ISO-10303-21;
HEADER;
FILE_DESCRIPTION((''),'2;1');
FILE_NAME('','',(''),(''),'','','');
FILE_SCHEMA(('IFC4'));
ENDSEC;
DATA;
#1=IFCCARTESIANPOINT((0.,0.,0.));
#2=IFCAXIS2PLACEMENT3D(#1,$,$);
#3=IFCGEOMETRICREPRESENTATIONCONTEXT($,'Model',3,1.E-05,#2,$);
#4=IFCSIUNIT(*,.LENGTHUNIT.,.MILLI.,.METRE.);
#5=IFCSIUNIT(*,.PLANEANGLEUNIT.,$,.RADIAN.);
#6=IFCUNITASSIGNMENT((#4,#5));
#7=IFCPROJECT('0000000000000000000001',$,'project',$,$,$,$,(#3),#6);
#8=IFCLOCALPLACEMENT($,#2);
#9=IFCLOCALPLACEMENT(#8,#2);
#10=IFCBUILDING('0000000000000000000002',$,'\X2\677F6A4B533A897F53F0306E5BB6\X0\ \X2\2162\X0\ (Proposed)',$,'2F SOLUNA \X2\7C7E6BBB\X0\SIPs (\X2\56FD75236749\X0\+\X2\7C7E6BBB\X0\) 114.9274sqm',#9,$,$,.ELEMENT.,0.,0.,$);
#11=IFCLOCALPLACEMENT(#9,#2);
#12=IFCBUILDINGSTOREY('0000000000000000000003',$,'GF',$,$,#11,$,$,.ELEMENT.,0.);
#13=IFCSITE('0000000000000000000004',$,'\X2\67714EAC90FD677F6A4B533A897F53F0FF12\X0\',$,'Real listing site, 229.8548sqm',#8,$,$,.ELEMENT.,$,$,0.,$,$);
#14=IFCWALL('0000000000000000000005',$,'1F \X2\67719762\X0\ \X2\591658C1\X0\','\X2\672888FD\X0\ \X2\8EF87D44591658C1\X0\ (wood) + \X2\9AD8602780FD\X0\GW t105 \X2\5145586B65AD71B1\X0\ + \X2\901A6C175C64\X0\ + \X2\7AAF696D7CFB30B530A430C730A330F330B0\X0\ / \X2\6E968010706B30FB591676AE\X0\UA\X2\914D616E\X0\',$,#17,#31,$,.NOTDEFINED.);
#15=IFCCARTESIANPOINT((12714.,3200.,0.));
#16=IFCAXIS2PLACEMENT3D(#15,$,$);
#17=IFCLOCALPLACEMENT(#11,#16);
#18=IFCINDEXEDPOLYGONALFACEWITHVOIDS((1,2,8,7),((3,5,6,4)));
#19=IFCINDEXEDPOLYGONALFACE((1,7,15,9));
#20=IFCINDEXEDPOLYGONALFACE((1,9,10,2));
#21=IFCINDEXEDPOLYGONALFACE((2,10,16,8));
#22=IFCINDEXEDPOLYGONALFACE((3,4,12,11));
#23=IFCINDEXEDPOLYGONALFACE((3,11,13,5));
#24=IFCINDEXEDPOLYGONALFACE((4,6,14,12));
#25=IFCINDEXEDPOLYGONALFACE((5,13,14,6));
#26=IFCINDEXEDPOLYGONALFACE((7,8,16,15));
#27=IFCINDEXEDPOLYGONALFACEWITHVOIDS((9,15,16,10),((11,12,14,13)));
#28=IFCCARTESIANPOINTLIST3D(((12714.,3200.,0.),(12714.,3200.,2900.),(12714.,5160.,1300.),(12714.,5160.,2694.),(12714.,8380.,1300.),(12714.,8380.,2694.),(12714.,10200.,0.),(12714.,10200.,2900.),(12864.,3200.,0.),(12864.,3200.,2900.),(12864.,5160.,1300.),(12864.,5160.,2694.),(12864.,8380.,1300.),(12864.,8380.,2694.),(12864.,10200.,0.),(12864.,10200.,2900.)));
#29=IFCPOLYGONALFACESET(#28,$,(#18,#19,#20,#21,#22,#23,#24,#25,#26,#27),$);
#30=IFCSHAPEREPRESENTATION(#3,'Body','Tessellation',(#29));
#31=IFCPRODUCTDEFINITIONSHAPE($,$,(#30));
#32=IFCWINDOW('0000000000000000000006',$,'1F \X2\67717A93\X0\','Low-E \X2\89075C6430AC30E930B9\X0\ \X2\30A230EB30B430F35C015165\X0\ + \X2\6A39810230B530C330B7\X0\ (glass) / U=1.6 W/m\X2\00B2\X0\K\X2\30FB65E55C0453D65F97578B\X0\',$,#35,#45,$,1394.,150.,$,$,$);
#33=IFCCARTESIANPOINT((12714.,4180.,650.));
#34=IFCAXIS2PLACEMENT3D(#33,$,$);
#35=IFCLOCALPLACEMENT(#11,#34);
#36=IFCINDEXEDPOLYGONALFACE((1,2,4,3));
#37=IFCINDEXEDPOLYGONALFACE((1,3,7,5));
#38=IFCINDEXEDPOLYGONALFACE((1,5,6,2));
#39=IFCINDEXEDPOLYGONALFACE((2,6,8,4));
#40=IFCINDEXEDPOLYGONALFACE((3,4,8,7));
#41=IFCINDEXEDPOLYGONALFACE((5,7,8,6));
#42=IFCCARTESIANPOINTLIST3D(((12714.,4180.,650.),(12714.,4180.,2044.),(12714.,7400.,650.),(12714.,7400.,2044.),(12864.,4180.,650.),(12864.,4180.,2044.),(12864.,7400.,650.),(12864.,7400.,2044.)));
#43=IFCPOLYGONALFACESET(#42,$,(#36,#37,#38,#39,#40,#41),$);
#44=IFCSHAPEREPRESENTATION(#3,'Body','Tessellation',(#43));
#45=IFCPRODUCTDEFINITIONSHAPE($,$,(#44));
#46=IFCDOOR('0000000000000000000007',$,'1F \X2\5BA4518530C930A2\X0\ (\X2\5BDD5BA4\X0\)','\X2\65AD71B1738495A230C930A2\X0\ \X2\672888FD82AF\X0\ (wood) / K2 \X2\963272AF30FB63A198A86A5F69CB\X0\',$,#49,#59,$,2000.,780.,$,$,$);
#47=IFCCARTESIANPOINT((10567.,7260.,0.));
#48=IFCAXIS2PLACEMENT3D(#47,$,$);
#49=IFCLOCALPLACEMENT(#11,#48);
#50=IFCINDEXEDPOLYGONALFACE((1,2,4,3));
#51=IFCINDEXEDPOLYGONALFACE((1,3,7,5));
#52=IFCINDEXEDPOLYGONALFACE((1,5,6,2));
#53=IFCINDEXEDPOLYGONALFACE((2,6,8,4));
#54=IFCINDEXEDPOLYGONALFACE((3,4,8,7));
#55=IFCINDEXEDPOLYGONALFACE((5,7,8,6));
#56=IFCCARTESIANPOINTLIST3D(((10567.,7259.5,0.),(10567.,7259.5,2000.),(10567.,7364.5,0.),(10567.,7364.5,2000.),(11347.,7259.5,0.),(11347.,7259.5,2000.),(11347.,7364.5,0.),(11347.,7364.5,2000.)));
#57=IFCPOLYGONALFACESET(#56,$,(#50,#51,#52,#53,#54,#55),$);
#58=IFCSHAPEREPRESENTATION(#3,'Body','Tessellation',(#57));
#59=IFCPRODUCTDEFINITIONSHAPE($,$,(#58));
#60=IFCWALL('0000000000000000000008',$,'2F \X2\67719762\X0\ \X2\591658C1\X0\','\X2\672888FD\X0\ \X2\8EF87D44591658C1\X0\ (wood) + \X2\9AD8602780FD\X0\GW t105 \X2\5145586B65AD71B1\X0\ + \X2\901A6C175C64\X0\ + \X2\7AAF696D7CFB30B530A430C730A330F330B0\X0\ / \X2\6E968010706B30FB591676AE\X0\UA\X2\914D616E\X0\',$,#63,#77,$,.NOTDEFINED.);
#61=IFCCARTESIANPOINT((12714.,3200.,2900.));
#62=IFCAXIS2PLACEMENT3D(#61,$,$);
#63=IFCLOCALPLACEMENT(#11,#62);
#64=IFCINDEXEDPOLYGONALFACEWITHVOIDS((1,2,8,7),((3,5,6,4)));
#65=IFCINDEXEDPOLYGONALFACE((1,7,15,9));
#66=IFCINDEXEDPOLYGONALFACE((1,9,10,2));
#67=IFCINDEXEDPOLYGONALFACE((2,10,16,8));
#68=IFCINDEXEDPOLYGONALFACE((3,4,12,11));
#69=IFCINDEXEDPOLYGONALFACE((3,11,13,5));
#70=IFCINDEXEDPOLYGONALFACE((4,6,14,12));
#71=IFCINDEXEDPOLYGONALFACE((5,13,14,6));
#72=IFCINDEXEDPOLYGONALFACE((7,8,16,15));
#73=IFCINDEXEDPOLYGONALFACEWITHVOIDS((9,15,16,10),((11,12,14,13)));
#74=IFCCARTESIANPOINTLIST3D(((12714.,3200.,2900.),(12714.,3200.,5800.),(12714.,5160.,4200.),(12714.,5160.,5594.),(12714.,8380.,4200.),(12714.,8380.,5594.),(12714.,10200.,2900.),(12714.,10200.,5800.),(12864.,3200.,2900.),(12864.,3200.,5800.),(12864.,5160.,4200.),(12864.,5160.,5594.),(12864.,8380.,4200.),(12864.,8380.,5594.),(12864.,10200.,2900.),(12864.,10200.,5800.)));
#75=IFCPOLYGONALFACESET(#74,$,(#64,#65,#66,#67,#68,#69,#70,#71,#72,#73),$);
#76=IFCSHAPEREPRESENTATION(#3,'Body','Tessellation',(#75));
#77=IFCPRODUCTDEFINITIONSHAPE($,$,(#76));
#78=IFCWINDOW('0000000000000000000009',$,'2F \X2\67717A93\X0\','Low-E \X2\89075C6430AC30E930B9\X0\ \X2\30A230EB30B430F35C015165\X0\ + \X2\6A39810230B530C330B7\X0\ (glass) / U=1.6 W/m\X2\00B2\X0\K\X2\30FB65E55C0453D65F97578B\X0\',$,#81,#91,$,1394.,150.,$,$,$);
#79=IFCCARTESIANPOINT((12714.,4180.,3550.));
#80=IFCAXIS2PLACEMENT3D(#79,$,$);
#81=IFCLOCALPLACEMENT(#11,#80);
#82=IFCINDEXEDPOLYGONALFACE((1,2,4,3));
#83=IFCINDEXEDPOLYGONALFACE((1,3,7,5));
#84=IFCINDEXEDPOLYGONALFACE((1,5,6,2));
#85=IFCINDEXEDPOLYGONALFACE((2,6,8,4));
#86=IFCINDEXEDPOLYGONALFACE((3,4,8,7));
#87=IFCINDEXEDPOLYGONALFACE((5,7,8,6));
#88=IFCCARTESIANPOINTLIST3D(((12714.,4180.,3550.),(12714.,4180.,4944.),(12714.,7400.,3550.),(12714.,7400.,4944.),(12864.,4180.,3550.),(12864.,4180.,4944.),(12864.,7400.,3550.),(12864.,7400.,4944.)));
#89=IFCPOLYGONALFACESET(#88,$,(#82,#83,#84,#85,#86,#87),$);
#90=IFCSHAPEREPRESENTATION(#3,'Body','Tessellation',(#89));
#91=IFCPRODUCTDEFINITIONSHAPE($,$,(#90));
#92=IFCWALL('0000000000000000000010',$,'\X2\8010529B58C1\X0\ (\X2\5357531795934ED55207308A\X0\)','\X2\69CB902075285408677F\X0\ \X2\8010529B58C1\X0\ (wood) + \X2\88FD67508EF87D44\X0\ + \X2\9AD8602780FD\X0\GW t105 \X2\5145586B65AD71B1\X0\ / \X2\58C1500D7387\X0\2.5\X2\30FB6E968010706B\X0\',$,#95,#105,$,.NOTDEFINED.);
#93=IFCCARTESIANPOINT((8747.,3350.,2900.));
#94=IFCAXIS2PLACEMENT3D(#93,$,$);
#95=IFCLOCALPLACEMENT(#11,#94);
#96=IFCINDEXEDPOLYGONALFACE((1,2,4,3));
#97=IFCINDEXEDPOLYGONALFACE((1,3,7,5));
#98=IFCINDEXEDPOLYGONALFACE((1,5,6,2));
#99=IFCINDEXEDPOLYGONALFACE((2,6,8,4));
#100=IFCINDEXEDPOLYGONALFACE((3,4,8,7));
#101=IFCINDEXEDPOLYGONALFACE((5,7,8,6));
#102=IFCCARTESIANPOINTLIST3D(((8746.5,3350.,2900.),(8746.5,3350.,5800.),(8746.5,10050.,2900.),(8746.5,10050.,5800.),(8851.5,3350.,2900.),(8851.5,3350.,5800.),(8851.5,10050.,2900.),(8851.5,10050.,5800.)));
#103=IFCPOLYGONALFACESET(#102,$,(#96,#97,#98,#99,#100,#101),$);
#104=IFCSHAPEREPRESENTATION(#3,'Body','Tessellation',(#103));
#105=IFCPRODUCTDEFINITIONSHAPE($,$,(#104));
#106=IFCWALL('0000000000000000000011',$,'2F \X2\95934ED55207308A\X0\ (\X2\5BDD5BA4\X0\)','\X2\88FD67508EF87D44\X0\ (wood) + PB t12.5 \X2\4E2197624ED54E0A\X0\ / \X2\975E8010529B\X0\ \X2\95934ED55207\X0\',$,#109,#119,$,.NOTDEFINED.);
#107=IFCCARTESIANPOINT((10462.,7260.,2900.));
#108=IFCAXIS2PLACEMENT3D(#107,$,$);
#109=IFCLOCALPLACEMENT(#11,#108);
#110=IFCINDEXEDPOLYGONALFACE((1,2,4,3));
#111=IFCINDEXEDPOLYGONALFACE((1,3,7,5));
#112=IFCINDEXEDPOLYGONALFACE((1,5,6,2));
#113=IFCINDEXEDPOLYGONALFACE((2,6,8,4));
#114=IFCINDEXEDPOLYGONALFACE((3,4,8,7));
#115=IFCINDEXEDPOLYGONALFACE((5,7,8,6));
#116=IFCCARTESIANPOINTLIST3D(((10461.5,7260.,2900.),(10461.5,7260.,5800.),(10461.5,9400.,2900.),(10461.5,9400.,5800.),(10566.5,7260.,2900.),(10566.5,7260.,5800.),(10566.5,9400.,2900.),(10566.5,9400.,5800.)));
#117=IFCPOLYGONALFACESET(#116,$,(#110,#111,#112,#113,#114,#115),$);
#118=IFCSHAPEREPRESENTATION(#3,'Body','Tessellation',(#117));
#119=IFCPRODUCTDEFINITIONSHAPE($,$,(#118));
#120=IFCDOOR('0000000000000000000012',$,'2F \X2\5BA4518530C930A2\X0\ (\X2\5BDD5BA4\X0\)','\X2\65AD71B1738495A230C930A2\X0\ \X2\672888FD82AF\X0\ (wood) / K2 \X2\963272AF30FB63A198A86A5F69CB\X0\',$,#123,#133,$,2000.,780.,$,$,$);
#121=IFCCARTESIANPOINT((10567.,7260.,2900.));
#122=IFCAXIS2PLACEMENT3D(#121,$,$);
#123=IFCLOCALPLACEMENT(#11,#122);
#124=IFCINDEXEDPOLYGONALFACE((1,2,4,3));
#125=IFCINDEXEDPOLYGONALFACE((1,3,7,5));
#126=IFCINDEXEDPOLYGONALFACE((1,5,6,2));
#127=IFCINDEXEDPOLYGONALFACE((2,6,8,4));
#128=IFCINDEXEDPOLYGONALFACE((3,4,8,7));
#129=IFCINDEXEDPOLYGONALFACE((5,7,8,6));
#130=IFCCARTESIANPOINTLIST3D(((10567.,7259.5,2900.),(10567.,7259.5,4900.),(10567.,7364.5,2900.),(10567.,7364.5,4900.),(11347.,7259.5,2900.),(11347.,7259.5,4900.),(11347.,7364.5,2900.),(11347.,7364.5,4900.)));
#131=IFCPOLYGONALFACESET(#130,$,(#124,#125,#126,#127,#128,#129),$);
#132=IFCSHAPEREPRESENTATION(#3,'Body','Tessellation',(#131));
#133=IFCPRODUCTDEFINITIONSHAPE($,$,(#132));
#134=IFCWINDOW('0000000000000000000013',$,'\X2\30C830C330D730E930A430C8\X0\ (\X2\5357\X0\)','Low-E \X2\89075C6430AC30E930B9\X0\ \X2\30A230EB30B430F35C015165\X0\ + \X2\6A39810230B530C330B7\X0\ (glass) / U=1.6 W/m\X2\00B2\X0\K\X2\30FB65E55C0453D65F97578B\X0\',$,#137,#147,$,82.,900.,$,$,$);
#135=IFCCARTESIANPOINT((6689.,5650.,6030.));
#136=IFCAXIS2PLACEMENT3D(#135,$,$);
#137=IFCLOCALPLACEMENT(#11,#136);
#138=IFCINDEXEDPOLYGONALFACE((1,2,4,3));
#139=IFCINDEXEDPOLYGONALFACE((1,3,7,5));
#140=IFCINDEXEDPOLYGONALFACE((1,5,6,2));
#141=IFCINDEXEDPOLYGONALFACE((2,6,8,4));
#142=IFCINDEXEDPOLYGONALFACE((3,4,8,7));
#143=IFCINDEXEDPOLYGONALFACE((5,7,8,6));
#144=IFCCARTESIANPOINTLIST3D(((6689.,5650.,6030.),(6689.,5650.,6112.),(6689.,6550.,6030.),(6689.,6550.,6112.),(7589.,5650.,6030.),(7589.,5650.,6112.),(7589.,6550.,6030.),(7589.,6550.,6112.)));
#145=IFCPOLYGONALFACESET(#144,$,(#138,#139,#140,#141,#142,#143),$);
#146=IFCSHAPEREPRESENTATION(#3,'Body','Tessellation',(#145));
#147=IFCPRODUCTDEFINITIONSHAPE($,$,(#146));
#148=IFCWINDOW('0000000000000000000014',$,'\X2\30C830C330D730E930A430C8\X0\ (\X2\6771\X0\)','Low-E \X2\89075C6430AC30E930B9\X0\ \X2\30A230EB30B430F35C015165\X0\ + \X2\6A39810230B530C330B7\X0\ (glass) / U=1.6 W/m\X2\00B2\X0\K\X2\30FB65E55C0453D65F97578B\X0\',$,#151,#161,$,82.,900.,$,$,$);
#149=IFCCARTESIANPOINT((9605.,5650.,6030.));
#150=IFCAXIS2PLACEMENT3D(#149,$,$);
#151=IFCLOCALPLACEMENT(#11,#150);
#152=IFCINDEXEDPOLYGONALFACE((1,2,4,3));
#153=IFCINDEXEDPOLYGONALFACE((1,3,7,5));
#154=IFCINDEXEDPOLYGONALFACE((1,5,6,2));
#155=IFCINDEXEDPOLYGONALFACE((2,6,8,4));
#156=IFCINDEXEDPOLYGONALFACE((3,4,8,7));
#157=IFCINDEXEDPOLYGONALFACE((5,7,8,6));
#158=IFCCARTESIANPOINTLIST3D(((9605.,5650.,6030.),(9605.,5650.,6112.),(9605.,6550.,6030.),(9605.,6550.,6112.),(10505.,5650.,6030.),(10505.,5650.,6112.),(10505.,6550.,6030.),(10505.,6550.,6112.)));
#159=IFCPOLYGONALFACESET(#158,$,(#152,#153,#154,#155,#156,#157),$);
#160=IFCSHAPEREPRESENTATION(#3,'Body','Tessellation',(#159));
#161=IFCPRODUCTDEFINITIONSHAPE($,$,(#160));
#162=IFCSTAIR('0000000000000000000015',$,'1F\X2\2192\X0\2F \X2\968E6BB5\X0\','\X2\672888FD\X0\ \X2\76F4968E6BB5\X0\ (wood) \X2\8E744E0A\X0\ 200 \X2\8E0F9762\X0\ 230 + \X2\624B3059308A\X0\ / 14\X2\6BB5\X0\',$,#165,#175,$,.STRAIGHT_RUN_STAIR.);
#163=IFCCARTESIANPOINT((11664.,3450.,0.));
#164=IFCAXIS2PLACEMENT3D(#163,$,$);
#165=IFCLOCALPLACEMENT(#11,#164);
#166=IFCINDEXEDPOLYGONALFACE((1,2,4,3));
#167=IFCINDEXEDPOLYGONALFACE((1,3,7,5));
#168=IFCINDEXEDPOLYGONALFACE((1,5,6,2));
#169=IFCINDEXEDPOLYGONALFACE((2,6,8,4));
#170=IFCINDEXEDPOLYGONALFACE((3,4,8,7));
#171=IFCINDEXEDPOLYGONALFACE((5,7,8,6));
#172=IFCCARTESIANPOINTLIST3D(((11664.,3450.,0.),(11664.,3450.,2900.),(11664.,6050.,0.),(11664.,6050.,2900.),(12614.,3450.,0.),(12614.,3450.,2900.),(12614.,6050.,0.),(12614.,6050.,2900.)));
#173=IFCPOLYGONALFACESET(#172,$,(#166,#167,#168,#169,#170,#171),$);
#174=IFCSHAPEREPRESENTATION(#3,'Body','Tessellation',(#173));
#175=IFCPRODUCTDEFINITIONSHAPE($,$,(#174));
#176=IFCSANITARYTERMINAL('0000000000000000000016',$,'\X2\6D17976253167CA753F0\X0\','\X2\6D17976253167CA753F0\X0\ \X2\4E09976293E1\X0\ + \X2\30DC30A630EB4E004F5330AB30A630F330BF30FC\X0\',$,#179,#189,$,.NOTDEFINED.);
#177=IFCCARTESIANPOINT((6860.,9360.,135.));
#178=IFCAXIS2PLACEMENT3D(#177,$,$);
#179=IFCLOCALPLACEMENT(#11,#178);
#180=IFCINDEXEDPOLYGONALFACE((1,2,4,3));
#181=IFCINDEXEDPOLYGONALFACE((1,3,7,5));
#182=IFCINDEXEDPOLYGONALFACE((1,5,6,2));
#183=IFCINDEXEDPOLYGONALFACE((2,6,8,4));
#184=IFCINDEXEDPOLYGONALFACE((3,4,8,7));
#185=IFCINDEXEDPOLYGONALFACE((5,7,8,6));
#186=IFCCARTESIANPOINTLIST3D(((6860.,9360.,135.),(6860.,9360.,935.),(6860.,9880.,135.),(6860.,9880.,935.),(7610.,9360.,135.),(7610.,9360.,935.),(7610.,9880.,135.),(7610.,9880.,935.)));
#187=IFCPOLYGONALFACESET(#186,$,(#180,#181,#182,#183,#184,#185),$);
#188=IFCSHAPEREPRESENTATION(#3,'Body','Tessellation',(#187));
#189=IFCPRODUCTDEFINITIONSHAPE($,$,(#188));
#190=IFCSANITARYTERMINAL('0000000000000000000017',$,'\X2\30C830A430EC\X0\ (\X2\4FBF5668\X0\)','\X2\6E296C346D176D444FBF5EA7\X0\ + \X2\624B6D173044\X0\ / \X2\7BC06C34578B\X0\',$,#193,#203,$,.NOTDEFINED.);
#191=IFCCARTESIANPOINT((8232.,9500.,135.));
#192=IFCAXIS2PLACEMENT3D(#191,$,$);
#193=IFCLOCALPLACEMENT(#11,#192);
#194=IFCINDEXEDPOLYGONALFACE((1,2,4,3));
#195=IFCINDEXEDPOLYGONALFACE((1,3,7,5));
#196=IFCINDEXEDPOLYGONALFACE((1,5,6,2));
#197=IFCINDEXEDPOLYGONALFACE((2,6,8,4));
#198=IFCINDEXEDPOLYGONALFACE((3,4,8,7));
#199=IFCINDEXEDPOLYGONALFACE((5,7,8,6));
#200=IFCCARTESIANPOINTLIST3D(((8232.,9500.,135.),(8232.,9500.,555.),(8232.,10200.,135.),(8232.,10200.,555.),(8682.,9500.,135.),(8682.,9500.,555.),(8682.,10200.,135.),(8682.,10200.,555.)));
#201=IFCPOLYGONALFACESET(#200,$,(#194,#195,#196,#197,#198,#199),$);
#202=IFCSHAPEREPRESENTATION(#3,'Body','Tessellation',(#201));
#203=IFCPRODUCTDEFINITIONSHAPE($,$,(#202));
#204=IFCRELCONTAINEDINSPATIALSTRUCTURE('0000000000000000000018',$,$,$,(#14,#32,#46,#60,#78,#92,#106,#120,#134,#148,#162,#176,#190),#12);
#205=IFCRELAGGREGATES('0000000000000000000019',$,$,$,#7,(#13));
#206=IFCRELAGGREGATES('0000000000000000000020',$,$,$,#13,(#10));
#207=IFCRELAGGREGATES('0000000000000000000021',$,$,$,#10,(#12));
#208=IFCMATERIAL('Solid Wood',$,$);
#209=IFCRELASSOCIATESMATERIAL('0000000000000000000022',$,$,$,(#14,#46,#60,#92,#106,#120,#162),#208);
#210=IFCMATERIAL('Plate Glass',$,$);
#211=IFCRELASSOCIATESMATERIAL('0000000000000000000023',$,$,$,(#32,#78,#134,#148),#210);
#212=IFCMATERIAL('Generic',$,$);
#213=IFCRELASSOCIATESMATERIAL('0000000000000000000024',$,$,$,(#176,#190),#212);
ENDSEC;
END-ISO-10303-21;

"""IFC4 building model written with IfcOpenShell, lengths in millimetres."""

from ifc_helpers import new_model, si_unit, frame, frame_2d, origin, place, context, project, spatial, rectangle, extrude, material, element, fill, save


model = new_model("IFC4")

# Units and contexts
model_context = context("Model", 3, precision=1e-05, world=origin())
ifc_project = project(units=[si_unit("LENGTHUNIT", "METRE", prefix="MILLI"), si_unit("PLANEANGLEUNIT", "RADIAN")], contexts=[model_context])

# Site, building, storey
site_placement = place(None, origin())
site = spatial("IfcSite", under=ifc_project, at=site_placement, Name="東京都板橋区西台２", ObjectType="Real listing site, 229.8548sqm", CompositionType="ELEMENT", RefElevation=0.0)
building_placement = place(site_placement, origin())
building = spatial("IfcBuilding", under=site, at=building_placement, Name="板橋区西台の家 Ⅲ (Proposed)", ObjectType="2F SOLUNA 籾殻SIPs (国産杉+籾殻) 114.9274sqm", CompositionType="ELEMENT", ElevationOfRefHeight=0.0, ElevationOfTerrain=0.0)
storey_placement = place(building_placement, origin())
storey = spatial("IfcBuildingStorey", under=building, at=storey_placement, Name="GF", CompositionType="ELEMENT", Elevation=0.0)

# Wall, opening, window
ifc_material_1 = material(Name="Solid Wood")
wall_1_placement = place(storey_placement, frame((12714.0, 3200.0, 0.0)))
wall_1 = element("IfcWall", 1, at=wall_1_placement, inside=storey, material=ifc_material_1, Name="1F 東面 外壁", Description="木製 軸組外壁 (wood) + 高性能GW t105 充填断熱 + 通気層 + 窯業系サイディング / 準耐火・外皮UA配慮", PredefinedType="NOTDEFINED", context=model_context, shape_type="SweptSolid", body=[
    extrude(rectangle(XDim=150.0, YDim=7000.0, at=frame_2d((75.0, 3500.0))), frame((12714.0, 3200.0, 0.0)), (0.0, 0.0, 1.0), 2900.0),
])
opening_1_placement = place(storey_placement, frame((12714.0, 4180.0, 650.0)))
opening_1 = element("IfcOpeningElement", 2, at=opening_1_placement, cuts=wall_1, PredefinedType="NOTDEFINED", context=model_context, shape_type="SweptSolid", body=[
    extrude(rectangle(XDim=150.0, YDim=3220.0, at=frame_2d((75.0, 1610.0))), frame((12714.0, 4180.0, 650.0)), (0.0, 0.0, 1.0), 1394.0),
])
ifc_material_2 = material(Name="Plate Glass")
window_1_placement = place(storey_placement, frame((12714.0, 4180.0, 650.0)))
window_1 = element("IfcWindow", 3, at=window_1_placement, inside=storey, material=ifc_material_2, Name="1F 東窓", Description="Low-E 複層ガラス アルゴン封入 + 樹脂サッシ (glass) / U=1.6 W/m²K・日射取得型", OverallHeight=1394.0, OverallWidth=150.0, context=model_context, shape_type="SweptSolid", body=[
    extrude(rectangle(XDim=150.0, YDim=3220.0, at=frame_2d((75.0, 1610.0))), frame((12714.0, 4180.0, 650.0)), (0.0, 0.0, 1.0), 1394.0),
])
fill(opening_1, window_1)

# Door
door_1_placement = place(storey_placement, frame((10567.0, 7260.0, 0.0)))
element("IfcDoor", 4, at=door_1_placement, inside=storey, material=ifc_material_1, Name="1F 室内ドア (寝室)", Description="断熱玄関ドア 木製芯 (wood) / K2 防犯・採風機構", OverallHeight=2000.0, OverallWidth=780.0, context=model_context, shape_type="SweptSolid", body=[
    extrude(rectangle(XDim=780.0, YDim=105.0, at=frame_2d((390.0, 52.0))), frame((10567.0, 7260.0, 0.0)), (0.0, 0.0, 1.0), 2000.0),
])

# Wall, opening, window
wall_2_placement = place(storey_placement, frame((12714.0, 3200.0, 2900.0)))
wall_2 = element("IfcWall", 5, at=wall_2_placement, inside=storey, material=ifc_material_1, Name="2F 東面 外壁", Description="木製 軸組外壁 (wood) + 高性能GW t105 充填断熱 + 通気層 + 窯業系サイディング / 準耐火・外皮UA配慮", PredefinedType="NOTDEFINED", context=model_context, shape_type="SweptSolid", body=[
    extrude(rectangle(XDim=150.0, YDim=7000.0, at=frame_2d((75.0, 3500.0))), frame((12714.0, 3200.0, 2900.0)), (0.0, 0.0, 1.0), 2900.0),
])
opening_2_placement = place(storey_placement, frame((12714.0, 4180.0, 3550.0)))
opening_2 = element("IfcOpeningElement", 6, at=opening_2_placement, cuts=wall_2, PredefinedType="NOTDEFINED", context=model_context, shape_type="SweptSolid", body=[
    extrude(rectangle(XDim=150.0, YDim=3220.0, at=frame_2d((75.0, 1610.0))), frame((12714.0, 4180.0, 3550.0)), (0.0, 0.0, 1.0), 1394.0),
])
window_2_placement = place(storey_placement, frame((12714.0, 4180.0, 3550.0)))
window_2 = element("IfcWindow", 7, at=window_2_placement, inside=storey, material=ifc_material_2, Name="2F 東窓", Description="Low-E 複層ガラス アルゴン封入 + 樹脂サッシ (glass) / U=1.6 W/m²K・日射取得型", OverallHeight=1394.0, OverallWidth=150.0, context=model_context, shape_type="SweptSolid", body=[
    extrude(rectangle(XDim=150.0, YDim=3220.0, at=frame_2d((75.0, 1610.0))), frame((12714.0, 4180.0, 3550.0)), (0.0, 0.0, 1.0), 1394.0),
])
fill(opening_2, window_2)

# Walls
wall_3_placement = place(storey_placement, frame((8747.0, 3350.0, 2900.0)))
element("IfcWall", 8, at=wall_3_placement, inside=storey, material=ifc_material_1, Name="耐力壁 (南北間仕切り)", Description="構造用合板 耐力壁 (wood) + 製材軸組 + 高性能GW t105 充填断熱 / 壁倍率2.5・準耐火", PredefinedType="NOTDEFINED", context=model_context, shape_type="SweptSolid", body=[
    extrude(rectangle(XDim=105.0, YDim=6700.0, at=frame_2d((52.0, 3350.0))), frame((8747.0, 3350.0, 2900.0)), (0.0, 0.0, 1.0), 2900.0),
])
wall_4_placement = place(storey_placement, frame((10462.0, 7260.0, 2900.0)))
element("IfcWall", 9, at=wall_4_placement, inside=storey, material=ifc_material_1, Name="2F 間仕切り (寝室)", Description="製材軸組 (wood) + PB t12.5 両面仕上 / 非耐力 間仕切", PredefinedType="NOTDEFINED", context=model_context, shape_type="SweptSolid", body=[
    extrude(rectangle(XDim=105.0, YDim=2140.0, at=frame_2d((52.0, 1070.0))), frame((10462.0, 7260.0, 2900.0)), (0.0, 0.0, 1.0), 2900.0),
])

# Door
door_2_placement = place(storey_placement, frame((10567.0, 7260.0, 2900.0)))
element("IfcDoor", 10, at=door_2_placement, inside=storey, material=ifc_material_1, Name="2F 室内ドア (寝室)", Description="断熱玄関ドア 木製芯 (wood) / K2 防犯・採風機構", OverallHeight=2000.0, OverallWidth=780.0, context=model_context, shape_type="SweptSolid", body=[
    extrude(rectangle(XDim=780.0, YDim=105.0, at=frame_2d((390.0, 52.0))), frame((10567.0, 7260.0, 2900.0)), (0.0, 0.0, 1.0), 2000.0),
])

# Windows
window_3_placement = place(storey_placement, frame((6689.0, 5650.0, 6030.0)))
element("IfcWindow", 11, at=window_3_placement, inside=storey, material=ifc_material_2, Name="トップライト (南)", Description="Low-E 複層ガラス アルゴン封入 + 樹脂サッシ (glass) / U=1.6 W/m²K・日射取得型", OverallHeight=82.0, OverallWidth=900.0, context=model_context, shape_type="SweptSolid", body=[
    extrude(rectangle(XDim=900.0, YDim=900.0, at=frame_2d((450.0, 450.0))), frame((6689.0, 5650.0, 6030.0)), (0.0, 0.0, 1.0), 82.0),
])
window_4_placement = place(storey_placement, frame((9605.0, 5650.0, 6030.0)))
element("IfcWindow", 12, at=window_4_placement, inside=storey, material=ifc_material_2, Name="トップライト (東)", Description="Low-E 複層ガラス アルゴン封入 + 樹脂サッシ (glass) / U=1.6 W/m²K・日射取得型", OverallHeight=82.0, OverallWidth=900.0, context=model_context, shape_type="SweptSolid", body=[
    extrude(rectangle(XDim=900.0, YDim=900.0, at=frame_2d((450.0, 450.0))), frame((9605.0, 5650.0, 6030.0)), (0.0, 0.0, 1.0), 82.0),
])

# Stair
stair_placement = place(storey_placement, frame((11664.0, 3450.0, 0.0)))
element("IfcStair", 13, at=stair_placement, inside=storey, material=ifc_material_1, Name="1F→2F 階段", Description="木製 直階段 (wood) 蹴上 200 踏面 230 + 手すり / 14段", PredefinedType="STRAIGHT_RUN_STAIR", context=model_context, shape_type="SweptSolid", body=[
    extrude(rectangle(XDim=950.0, YDim=2600.0, at=frame_2d((475.0, 1300.0))), frame((11664.0, 3450.0, 0.0)), (0.0, 0.0, 1.0), 2900.0),
])

# Sanitary terminals
ifc_material_3 = material(Name="Generic")
sanitary_terminal_1_placement = place(storey_placement, frame((6860.0, 9360.0, 135.0)))
element("IfcSanitaryTerminal", 14, at=sanitary_terminal_1_placement, inside=storey, material=ifc_material_3, Name="洗面化粧台", Description="洗面化粧台 三面鏡 + ボウル一体カウンター", PredefinedType="NOTDEFINED", context=model_context, shape_type="SweptSolid", body=[
    extrude(rectangle(XDim=750.0, YDim=520.0, at=frame_2d((375.0, 260.0))), frame((6860.0, 9360.0, 135.0)), (0.0, 0.0, 1.0), 800.0),
])
sanitary_terminal_2_placement = place(storey_placement, frame((8232.0, 9500.0, 135.0)))
element("IfcSanitaryTerminal", 15, at=sanitary_terminal_2_placement, inside=storey, material=ifc_material_3, Name="トイレ (便器)", Description="温水洗浄便座 + 手洗い / 節水型", PredefinedType="NOTDEFINED", context=model_context, shape_type="SweptSolid", body=[
    extrude(rectangle(XDim=450.0, YDim=700.0, at=frame_2d((225.0, 350.0))), frame((8232.0, 9500.0, 135.0)), (0.0, 0.0, 1.0), 420.0),
])

save(model, "model.ifc")
